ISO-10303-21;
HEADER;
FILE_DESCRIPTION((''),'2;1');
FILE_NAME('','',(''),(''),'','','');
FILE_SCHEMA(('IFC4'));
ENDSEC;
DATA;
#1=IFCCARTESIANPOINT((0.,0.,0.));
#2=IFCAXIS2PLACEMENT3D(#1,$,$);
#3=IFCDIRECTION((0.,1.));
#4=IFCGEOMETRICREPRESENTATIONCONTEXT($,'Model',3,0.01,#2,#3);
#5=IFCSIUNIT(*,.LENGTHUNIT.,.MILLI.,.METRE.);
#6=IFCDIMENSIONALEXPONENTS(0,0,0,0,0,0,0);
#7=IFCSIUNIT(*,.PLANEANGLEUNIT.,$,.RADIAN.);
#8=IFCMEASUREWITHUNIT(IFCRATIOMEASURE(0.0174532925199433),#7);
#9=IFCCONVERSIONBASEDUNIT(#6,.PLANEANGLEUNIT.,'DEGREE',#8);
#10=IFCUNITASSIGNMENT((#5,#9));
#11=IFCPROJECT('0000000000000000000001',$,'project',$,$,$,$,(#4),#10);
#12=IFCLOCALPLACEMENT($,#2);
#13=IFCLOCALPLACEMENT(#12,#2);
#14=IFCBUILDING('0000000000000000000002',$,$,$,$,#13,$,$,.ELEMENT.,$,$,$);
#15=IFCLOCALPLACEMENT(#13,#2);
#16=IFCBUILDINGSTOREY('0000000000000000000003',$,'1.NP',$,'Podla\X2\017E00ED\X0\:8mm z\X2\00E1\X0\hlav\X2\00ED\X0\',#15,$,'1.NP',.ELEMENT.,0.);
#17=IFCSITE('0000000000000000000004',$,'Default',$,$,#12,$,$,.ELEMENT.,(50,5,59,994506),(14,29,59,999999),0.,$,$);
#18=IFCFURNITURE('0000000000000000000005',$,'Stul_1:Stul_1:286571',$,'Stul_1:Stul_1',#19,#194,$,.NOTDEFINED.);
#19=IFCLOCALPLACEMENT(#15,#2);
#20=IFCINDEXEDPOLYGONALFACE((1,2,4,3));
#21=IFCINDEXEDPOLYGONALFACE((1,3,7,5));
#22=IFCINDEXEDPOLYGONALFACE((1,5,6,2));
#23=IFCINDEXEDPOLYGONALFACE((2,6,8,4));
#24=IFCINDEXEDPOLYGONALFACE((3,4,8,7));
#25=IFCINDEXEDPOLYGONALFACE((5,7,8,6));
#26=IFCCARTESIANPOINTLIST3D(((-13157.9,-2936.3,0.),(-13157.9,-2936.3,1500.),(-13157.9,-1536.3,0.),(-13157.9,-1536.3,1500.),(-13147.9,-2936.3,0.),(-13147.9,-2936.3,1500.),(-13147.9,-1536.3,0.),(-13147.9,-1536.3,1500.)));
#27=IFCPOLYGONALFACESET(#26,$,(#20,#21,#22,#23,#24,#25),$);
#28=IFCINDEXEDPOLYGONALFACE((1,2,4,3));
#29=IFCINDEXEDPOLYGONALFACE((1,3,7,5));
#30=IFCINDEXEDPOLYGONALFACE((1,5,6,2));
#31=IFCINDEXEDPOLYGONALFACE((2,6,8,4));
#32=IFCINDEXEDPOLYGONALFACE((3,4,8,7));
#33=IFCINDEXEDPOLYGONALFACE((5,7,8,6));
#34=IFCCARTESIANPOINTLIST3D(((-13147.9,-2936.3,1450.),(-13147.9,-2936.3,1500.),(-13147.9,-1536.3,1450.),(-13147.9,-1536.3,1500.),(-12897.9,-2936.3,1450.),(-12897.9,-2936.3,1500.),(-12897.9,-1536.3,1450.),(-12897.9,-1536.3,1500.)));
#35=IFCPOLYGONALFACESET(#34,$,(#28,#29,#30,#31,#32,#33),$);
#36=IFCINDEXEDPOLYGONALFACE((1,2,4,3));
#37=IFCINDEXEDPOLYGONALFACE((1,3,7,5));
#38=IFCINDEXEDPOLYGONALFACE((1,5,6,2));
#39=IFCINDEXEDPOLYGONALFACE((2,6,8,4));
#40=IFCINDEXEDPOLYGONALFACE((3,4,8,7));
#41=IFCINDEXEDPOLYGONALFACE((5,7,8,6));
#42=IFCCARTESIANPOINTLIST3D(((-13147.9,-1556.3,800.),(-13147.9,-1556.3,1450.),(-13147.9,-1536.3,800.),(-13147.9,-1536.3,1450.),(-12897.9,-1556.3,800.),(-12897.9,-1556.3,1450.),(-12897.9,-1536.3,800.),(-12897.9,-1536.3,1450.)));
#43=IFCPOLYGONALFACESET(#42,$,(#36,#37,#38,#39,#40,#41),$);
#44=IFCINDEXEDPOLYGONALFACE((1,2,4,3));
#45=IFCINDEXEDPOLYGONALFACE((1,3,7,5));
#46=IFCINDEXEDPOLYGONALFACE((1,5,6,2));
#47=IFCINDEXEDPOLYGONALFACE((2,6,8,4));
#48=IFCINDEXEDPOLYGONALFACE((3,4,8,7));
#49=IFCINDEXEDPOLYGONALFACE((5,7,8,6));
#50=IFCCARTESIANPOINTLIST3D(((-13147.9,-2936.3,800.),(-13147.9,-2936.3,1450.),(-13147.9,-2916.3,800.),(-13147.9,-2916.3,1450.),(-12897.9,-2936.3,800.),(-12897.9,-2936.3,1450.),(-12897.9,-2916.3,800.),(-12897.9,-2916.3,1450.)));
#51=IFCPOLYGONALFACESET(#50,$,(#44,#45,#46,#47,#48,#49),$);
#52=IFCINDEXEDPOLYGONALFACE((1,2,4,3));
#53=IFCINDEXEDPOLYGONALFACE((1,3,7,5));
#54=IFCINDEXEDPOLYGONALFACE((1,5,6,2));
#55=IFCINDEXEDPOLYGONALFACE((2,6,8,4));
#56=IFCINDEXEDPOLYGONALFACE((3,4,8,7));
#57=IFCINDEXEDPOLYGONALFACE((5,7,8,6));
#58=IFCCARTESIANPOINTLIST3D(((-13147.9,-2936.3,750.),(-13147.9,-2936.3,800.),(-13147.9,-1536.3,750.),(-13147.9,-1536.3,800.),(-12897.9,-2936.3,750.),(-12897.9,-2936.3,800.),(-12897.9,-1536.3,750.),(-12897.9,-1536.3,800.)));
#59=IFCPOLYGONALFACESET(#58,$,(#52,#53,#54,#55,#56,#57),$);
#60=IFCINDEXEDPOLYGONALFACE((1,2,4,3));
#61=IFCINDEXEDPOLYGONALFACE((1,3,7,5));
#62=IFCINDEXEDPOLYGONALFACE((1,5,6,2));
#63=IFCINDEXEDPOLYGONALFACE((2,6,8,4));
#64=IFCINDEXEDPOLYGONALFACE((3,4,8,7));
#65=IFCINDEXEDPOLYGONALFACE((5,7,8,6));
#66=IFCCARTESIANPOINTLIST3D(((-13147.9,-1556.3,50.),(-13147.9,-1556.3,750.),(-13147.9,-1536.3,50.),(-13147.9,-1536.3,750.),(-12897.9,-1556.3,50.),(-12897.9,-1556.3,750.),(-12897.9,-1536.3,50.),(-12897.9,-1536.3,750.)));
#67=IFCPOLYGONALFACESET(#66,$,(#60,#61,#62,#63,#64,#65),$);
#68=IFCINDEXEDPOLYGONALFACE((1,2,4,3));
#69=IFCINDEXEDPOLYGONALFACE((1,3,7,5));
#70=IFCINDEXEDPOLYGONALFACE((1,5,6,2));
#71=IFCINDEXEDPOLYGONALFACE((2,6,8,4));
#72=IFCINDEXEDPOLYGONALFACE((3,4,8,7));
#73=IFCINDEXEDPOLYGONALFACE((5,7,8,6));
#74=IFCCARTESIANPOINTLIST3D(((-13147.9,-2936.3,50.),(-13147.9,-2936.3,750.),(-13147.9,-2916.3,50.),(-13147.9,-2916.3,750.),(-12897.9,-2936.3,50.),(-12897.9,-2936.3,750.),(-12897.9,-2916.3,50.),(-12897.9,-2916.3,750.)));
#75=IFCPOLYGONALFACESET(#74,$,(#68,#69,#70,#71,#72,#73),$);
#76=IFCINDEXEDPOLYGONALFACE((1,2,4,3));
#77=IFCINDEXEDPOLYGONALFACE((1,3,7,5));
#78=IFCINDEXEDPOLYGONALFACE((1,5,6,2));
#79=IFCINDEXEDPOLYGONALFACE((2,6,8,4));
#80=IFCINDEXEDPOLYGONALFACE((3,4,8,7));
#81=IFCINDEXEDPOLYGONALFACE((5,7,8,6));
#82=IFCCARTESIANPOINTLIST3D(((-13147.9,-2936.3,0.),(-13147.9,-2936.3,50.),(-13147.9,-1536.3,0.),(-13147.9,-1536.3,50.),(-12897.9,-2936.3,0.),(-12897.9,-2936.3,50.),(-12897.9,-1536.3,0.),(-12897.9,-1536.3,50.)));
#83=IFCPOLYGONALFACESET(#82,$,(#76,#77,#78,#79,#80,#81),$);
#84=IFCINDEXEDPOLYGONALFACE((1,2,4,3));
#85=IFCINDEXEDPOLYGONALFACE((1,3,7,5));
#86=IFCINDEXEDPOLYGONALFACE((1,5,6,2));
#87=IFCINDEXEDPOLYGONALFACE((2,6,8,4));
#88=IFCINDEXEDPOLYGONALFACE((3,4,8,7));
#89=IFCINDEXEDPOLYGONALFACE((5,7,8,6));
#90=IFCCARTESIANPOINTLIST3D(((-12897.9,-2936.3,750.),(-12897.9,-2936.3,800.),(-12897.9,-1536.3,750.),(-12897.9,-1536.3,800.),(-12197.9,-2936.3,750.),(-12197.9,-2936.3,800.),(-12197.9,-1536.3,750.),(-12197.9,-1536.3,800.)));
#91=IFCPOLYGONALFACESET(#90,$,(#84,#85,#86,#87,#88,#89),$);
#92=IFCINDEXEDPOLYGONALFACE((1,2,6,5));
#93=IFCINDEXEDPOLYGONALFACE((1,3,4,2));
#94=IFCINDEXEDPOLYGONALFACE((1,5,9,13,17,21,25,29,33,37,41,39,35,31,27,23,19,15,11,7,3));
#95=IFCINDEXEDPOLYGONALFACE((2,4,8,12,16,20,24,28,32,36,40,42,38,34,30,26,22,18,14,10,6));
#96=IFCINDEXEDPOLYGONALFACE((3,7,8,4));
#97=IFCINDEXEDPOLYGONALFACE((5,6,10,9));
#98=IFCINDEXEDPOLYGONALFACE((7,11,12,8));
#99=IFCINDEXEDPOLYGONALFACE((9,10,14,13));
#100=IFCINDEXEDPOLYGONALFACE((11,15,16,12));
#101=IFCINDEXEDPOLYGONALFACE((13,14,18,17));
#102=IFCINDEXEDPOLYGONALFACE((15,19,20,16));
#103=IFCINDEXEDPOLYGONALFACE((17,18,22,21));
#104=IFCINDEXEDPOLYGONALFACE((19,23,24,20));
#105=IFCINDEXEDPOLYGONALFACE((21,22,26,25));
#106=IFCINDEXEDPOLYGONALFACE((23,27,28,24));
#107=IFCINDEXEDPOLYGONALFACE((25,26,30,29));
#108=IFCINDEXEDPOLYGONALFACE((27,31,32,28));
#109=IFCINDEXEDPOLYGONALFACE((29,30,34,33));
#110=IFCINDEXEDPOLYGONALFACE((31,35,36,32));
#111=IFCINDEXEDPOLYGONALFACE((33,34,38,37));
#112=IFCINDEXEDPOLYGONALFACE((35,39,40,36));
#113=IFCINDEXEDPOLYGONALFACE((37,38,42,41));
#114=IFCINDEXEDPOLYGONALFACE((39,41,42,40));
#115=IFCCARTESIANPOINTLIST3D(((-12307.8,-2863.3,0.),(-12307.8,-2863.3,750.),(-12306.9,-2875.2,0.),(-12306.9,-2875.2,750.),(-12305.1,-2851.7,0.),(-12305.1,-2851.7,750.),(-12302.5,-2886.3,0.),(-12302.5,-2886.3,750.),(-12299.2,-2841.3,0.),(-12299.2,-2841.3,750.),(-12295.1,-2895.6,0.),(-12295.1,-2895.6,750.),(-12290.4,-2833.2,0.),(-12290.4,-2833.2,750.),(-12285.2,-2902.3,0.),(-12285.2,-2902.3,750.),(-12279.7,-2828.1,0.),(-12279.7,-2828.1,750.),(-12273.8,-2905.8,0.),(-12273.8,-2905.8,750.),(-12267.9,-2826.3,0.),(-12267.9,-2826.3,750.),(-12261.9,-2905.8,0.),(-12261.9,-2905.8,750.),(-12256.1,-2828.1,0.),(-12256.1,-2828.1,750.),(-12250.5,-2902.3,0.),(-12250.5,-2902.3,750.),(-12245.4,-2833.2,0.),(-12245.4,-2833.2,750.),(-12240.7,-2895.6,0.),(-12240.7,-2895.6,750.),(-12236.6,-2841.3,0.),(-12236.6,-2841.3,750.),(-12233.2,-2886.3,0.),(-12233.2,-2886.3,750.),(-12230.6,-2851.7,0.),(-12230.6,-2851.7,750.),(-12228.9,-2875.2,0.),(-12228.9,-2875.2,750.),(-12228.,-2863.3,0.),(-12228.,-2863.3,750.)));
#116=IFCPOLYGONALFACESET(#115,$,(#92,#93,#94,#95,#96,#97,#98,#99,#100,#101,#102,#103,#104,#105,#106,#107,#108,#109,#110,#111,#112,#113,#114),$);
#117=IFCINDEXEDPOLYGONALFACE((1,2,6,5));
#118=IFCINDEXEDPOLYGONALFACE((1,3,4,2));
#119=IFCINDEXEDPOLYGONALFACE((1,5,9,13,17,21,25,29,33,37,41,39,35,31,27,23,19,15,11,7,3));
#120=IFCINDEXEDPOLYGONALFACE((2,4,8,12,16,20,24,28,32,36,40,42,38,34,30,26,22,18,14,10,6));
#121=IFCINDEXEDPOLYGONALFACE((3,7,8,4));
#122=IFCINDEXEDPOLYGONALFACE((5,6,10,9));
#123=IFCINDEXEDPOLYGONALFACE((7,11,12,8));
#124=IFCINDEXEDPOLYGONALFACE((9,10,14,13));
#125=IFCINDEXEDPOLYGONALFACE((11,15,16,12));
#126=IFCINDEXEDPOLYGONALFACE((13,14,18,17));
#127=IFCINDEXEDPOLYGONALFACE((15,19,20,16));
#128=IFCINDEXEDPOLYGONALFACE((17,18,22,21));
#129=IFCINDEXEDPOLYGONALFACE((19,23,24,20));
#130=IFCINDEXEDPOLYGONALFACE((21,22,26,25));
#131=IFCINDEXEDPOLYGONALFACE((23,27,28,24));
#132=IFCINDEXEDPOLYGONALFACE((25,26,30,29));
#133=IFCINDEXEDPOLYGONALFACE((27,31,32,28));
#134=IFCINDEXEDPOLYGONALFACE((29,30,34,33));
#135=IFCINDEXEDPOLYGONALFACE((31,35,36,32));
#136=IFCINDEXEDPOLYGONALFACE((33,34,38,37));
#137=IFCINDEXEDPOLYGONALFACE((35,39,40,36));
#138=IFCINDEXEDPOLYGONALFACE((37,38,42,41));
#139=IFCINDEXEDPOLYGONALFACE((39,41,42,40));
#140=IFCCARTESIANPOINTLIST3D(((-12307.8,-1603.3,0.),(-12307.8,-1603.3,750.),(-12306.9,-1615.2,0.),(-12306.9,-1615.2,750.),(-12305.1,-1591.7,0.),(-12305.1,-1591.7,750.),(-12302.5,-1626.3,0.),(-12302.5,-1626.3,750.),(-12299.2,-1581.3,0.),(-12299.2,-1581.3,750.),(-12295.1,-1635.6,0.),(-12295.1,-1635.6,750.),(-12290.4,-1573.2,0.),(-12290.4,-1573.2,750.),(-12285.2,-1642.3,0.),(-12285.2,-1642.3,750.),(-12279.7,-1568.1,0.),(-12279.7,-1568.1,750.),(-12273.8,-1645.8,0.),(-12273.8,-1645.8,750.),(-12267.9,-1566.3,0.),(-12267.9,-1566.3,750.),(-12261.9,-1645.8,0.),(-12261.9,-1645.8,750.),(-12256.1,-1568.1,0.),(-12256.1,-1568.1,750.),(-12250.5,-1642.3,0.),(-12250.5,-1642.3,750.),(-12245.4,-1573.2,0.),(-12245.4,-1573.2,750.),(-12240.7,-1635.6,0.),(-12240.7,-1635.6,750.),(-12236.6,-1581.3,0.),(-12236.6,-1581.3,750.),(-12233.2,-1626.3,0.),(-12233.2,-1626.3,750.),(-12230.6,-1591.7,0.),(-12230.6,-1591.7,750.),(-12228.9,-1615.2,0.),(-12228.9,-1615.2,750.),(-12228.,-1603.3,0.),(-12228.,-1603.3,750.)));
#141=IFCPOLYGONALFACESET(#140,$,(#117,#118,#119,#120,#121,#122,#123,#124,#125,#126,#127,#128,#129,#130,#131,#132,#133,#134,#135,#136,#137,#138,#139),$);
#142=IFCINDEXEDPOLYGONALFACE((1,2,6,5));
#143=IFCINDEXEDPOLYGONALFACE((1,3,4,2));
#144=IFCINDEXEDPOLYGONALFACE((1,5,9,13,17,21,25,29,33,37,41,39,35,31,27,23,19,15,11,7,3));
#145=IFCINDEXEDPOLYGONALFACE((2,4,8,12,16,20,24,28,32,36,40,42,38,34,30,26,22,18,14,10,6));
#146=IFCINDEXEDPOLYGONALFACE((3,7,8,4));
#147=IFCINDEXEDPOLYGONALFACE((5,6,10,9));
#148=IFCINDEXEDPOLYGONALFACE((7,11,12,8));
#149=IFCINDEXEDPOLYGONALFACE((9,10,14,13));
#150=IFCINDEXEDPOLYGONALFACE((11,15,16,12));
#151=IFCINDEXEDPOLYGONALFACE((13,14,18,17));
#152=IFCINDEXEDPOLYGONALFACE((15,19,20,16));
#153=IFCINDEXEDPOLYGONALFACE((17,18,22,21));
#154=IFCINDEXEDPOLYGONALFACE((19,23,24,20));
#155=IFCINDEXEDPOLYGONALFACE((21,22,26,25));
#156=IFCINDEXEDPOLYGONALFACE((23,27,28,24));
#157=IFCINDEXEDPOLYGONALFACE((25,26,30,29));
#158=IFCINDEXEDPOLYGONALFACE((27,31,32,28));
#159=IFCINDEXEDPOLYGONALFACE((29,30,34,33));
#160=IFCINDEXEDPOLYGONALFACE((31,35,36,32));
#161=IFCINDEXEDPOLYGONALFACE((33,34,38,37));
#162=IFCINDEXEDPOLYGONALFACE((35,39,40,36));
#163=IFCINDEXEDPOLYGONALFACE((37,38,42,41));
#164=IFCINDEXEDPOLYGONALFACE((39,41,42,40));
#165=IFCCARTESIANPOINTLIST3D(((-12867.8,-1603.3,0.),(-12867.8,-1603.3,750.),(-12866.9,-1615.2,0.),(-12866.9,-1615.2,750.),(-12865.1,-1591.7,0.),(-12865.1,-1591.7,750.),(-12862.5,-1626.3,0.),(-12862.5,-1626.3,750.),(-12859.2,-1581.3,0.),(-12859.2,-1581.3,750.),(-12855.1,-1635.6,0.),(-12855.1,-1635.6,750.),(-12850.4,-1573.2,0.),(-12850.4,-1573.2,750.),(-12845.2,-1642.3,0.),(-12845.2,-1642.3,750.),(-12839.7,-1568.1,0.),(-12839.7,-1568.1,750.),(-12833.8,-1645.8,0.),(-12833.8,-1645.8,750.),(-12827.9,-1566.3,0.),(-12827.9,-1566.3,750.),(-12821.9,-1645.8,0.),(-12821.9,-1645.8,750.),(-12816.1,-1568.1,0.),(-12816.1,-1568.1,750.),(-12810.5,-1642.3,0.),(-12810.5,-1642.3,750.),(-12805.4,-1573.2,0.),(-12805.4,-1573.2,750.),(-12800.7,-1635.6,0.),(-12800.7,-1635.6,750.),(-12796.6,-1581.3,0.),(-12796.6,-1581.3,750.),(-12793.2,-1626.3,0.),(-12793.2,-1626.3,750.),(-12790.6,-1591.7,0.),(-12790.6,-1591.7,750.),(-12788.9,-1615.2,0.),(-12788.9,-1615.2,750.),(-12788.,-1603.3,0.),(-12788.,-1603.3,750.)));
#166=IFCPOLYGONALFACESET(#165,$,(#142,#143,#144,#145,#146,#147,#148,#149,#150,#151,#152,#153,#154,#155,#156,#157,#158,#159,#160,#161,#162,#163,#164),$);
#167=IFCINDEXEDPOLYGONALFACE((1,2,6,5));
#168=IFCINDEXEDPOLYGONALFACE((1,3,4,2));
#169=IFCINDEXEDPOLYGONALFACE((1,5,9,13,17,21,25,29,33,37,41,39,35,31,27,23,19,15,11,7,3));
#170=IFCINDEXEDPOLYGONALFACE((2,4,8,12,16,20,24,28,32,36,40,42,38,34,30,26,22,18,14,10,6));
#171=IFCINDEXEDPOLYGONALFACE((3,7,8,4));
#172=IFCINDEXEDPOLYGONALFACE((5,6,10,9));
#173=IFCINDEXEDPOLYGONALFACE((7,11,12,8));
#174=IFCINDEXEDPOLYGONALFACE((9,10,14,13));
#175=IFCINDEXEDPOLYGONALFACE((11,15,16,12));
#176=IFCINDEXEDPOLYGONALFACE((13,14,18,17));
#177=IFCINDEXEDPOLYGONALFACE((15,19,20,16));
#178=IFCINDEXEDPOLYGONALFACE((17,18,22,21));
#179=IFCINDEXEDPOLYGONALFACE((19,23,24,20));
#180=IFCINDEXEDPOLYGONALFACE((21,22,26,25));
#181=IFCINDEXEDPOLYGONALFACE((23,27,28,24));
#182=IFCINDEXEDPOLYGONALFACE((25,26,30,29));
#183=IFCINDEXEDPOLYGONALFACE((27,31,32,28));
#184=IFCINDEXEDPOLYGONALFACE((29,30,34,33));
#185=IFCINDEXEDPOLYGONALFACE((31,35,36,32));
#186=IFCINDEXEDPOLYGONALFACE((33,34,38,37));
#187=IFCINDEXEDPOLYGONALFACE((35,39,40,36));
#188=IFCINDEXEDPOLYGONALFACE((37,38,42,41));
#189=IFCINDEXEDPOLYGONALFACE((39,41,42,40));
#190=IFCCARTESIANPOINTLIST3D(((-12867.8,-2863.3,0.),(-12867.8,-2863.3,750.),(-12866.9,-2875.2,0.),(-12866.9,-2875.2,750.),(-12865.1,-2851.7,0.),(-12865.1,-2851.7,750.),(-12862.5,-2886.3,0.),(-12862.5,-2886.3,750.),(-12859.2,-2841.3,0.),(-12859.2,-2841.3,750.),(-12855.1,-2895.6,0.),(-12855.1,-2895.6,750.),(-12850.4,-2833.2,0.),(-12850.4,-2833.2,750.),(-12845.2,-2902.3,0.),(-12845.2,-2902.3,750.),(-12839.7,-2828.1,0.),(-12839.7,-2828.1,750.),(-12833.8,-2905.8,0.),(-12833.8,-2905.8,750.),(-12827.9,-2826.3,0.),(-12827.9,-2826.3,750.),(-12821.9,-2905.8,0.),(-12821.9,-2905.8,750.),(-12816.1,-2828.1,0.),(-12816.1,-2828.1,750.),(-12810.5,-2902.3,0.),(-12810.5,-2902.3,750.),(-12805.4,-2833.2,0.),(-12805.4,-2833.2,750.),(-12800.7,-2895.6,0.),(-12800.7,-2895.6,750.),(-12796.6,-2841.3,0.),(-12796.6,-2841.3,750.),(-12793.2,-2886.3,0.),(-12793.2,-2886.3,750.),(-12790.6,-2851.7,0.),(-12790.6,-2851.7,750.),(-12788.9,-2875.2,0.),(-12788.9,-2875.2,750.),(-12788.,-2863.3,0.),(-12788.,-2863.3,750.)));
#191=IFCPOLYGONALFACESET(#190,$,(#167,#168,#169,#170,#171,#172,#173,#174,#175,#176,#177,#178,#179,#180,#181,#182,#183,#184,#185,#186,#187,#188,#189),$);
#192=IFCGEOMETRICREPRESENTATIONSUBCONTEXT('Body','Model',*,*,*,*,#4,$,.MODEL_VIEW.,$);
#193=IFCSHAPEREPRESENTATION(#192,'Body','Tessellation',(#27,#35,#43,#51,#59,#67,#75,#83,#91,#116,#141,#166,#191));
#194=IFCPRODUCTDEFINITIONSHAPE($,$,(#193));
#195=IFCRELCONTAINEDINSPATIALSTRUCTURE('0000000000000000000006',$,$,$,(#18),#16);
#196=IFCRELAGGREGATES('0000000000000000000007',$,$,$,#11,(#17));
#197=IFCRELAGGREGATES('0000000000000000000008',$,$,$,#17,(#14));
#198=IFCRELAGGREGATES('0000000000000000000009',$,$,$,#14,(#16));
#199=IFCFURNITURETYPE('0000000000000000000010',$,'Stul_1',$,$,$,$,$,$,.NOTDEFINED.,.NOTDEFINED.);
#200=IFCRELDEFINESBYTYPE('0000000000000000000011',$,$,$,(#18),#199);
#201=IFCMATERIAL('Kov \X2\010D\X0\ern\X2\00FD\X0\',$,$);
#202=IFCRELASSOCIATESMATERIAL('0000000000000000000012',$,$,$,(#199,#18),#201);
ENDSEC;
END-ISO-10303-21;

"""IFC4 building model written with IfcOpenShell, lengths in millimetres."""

from ifc_helpers import new_model, entity, si_unit, converted_unit, direction, frame, frame_2d, origin, origin_2d_with_axis, place, context, subcontext, project, spatial, rectangle, circle, extrude, source, transform, mapped, material, type_object, type_shapes, element, save


model = new_model("IFC4")

# Units and contexts
model_context = context("Model", 3, precision=0.01, world=origin(), true_north=direction((0.0, 1.0)))
body_context = subcontext(model_context, "Body", "Model", "MODEL_VIEW")
ifc_project = project(units=[si_unit("LENGTHUNIT", "METRE", prefix="MILLI"), converted_unit("PLANEANGLEUNIT", "DEGREE", entity("IfcRatioMeasure", 0.0174532925199433), si_unit("PLANEANGLEUNIT", "RADIAN"), dimensions=[0, 0, 0, 0, 0, 0, 0])], contexts=[model_context])

# Site, building, storey
site_placement = place(None, origin())
site = spatial("IfcSite", under=ifc_project, at=site_placement, Name="Default", CompositionType="ELEMENT", RefLatitude=(50, 5, 59, 994506), RefLongitude=(14, 29, 59, 999999), RefElevation=0.0)
building_placement = place(site_placement, origin())
building = spatial("IfcBuilding", under=site, at=building_placement, CompositionType="ELEMENT")
storey_placement = place(building_placement, origin())
storey = spatial("IfcBuildingStorey", under=building, at=storey_placement, Name="1.NP", ObjectType="Podlaží:8mm záhlaví", LongName="1.NP", CompositionType="ELEMENT", Elevation=0.0)

# Furniture
ifc_material_1 = material(Name="Kov černý")
furniture_type = type_object("IfcFurnitureType", Name="Stul_1", AssemblyPlace="NOTDEFINED", PredefinedType="NOTDEFINED", material=ifc_material_1)
shared_shape_1 = source(origin(), body_context, "Body", "SweptSolid", [
    extrude(rectangle(XDim=1400.0, YDim=10.0, at=origin_2d_with_axis()), frame((0.0, 605.0, 0.0), z_axis=(0.0, 0.0, 1.0), x_axis=(-1.0, 0.0, 0.0)), (0.0, 0.0, 1.0), 1500.0),
    extrude(rectangle(XDim=1400.0, YDim=250.0, at=frame_2d((0.0, 0.0), x_axis=(1.0, 0.0))), frame((0.0, 475.0, 1450.0), z_axis=(0.0, 0.0, 1.0), x_axis=(-1.0, 0.0, 0.0)), (0.0, 0.0, 1.0), 50.0),
    extrude(rectangle(XDim=20.0, YDim=250.0, at=origin_2d_with_axis()), frame((690.0, 475.0, 800.0), z_axis=(0.0, 0.0, 1.0), x_axis=(-1.0, 0.0, 0.0)), (0.0, 0.0, 1.0), 650.0),
    extrude(rectangle(XDim=20.0, YDim=250.0, at=frame_2d((0.0, 0.0), x_axis=(1.0, 0.0))), frame((-690.0, 475.0, 800.0), z_axis=(0.0, 0.0, 1.0), x_axis=(-1.0, 0.0, 0.0)), (0.0, 0.0, 1.0), 650.0),
    extrude(rectangle(XDim=1400.0, YDim=250.0, at=origin_2d_with_axis()), frame((0.0, 475.0, 750.0), z_axis=(0.0, 0.0, 1.0), x_axis=(-1.0, 0.0, 0.0)), (0.0, 0.0, 1.0), 50.0),
    extrude(rectangle(XDim=20.0, YDim=250.0, at=origin_2d_with_axis()), frame((690.0, 475.0, 50.0), z_axis=(0.0, 0.0, 1.0), x_axis=(-1.0, 0.0, 0.0)), (0.0, 0.0, 1.0), 700.0),
    extrude(rectangle(XDim=20.0, YDim=250.0, at=frame_2d((0.0, 0.0), x_axis=(1.0, 0.0))), frame((-690.0, 475.0, 50.0), z_axis=(0.0, 0.0, 1.0), x_axis=(-1.0, 0.0, 0.0)), (0.0, 0.0, 1.0), 700.0),
    extrude(rectangle(XDim=1400.0, YDim=250.0, at=origin_2d_with_axis()), frame((0.0, 475.0, 0.0), z_axis=(0.0, 0.0, 1.0), x_axis=(-1.0, 0.0, 0.0)), (0.0, 0.0, 1.0), 50.0),
    extrude(rectangle(XDim=1400.0, YDim=700.0, at=origin_2d_with_axis()), frame((0.0, 0.0, 750.0), z_axis=(0.0, 0.0, 1.0), x_axis=(-1.0, 0.0, 0.0)), (0.0, 0.0, 1.0), 50.0),
    extrude(circle(Radius=40.0, at=frame_2d((0.0, 0.0), x_axis=(1.0, 0.0))), frame((-630.0, -280.0, 0.0)), (0.0, 0.0, 1.0), 750.0),
    extrude(circle(Radius=40.0, at=frame_2d((0.0, 0.0), x_axis=(1.0, 0.0))), frame((630.0, -280.0, 0.0)), (0.0, 0.0, 1.0), 750.0),
    extrude(circle(Radius=40.0, at=frame_2d((0.0, 0.0), x_axis=(1.0, 0.0))), frame((630.0, 280.0, 0.0)), (0.0, 0.0, 1.0), 750.0),
    extrude(circle(Radius=40.0, at=frame_2d((0.0, 0.0), x_axis=(1.0, 0.0))), frame((-630.0, 280.0, 0.0)), (0.0, 0.0, 1.0), 750.0),
])
type_shapes(furniture_type, [shared_shape_1])
for number, where, z_axis, x_axis, name in (
    (1, (-12547.9, -2236.3, 0.0), (0.0, 0.0, 1.0), (0.0, 1.0, 0.0), "Stul_1:Stul_1:286571"),
):
    element("IfcFurniture", number, at=place(storey_placement, frame(where, z_axis=z_axis, x_axis=x_axis)), inside=storey, type_object=furniture_type, material=ifc_material_1, Name=name, ObjectType="Stul_1:Stul_1", PredefinedType="NOTDEFINED", context=body_context, shape_type="MappedRepresentation", body=[
        mapped(shared_shape_1, transform((0.0, 0.0, 0.0), scale=1.0)),
    ])

save(model, "model.ifc")
